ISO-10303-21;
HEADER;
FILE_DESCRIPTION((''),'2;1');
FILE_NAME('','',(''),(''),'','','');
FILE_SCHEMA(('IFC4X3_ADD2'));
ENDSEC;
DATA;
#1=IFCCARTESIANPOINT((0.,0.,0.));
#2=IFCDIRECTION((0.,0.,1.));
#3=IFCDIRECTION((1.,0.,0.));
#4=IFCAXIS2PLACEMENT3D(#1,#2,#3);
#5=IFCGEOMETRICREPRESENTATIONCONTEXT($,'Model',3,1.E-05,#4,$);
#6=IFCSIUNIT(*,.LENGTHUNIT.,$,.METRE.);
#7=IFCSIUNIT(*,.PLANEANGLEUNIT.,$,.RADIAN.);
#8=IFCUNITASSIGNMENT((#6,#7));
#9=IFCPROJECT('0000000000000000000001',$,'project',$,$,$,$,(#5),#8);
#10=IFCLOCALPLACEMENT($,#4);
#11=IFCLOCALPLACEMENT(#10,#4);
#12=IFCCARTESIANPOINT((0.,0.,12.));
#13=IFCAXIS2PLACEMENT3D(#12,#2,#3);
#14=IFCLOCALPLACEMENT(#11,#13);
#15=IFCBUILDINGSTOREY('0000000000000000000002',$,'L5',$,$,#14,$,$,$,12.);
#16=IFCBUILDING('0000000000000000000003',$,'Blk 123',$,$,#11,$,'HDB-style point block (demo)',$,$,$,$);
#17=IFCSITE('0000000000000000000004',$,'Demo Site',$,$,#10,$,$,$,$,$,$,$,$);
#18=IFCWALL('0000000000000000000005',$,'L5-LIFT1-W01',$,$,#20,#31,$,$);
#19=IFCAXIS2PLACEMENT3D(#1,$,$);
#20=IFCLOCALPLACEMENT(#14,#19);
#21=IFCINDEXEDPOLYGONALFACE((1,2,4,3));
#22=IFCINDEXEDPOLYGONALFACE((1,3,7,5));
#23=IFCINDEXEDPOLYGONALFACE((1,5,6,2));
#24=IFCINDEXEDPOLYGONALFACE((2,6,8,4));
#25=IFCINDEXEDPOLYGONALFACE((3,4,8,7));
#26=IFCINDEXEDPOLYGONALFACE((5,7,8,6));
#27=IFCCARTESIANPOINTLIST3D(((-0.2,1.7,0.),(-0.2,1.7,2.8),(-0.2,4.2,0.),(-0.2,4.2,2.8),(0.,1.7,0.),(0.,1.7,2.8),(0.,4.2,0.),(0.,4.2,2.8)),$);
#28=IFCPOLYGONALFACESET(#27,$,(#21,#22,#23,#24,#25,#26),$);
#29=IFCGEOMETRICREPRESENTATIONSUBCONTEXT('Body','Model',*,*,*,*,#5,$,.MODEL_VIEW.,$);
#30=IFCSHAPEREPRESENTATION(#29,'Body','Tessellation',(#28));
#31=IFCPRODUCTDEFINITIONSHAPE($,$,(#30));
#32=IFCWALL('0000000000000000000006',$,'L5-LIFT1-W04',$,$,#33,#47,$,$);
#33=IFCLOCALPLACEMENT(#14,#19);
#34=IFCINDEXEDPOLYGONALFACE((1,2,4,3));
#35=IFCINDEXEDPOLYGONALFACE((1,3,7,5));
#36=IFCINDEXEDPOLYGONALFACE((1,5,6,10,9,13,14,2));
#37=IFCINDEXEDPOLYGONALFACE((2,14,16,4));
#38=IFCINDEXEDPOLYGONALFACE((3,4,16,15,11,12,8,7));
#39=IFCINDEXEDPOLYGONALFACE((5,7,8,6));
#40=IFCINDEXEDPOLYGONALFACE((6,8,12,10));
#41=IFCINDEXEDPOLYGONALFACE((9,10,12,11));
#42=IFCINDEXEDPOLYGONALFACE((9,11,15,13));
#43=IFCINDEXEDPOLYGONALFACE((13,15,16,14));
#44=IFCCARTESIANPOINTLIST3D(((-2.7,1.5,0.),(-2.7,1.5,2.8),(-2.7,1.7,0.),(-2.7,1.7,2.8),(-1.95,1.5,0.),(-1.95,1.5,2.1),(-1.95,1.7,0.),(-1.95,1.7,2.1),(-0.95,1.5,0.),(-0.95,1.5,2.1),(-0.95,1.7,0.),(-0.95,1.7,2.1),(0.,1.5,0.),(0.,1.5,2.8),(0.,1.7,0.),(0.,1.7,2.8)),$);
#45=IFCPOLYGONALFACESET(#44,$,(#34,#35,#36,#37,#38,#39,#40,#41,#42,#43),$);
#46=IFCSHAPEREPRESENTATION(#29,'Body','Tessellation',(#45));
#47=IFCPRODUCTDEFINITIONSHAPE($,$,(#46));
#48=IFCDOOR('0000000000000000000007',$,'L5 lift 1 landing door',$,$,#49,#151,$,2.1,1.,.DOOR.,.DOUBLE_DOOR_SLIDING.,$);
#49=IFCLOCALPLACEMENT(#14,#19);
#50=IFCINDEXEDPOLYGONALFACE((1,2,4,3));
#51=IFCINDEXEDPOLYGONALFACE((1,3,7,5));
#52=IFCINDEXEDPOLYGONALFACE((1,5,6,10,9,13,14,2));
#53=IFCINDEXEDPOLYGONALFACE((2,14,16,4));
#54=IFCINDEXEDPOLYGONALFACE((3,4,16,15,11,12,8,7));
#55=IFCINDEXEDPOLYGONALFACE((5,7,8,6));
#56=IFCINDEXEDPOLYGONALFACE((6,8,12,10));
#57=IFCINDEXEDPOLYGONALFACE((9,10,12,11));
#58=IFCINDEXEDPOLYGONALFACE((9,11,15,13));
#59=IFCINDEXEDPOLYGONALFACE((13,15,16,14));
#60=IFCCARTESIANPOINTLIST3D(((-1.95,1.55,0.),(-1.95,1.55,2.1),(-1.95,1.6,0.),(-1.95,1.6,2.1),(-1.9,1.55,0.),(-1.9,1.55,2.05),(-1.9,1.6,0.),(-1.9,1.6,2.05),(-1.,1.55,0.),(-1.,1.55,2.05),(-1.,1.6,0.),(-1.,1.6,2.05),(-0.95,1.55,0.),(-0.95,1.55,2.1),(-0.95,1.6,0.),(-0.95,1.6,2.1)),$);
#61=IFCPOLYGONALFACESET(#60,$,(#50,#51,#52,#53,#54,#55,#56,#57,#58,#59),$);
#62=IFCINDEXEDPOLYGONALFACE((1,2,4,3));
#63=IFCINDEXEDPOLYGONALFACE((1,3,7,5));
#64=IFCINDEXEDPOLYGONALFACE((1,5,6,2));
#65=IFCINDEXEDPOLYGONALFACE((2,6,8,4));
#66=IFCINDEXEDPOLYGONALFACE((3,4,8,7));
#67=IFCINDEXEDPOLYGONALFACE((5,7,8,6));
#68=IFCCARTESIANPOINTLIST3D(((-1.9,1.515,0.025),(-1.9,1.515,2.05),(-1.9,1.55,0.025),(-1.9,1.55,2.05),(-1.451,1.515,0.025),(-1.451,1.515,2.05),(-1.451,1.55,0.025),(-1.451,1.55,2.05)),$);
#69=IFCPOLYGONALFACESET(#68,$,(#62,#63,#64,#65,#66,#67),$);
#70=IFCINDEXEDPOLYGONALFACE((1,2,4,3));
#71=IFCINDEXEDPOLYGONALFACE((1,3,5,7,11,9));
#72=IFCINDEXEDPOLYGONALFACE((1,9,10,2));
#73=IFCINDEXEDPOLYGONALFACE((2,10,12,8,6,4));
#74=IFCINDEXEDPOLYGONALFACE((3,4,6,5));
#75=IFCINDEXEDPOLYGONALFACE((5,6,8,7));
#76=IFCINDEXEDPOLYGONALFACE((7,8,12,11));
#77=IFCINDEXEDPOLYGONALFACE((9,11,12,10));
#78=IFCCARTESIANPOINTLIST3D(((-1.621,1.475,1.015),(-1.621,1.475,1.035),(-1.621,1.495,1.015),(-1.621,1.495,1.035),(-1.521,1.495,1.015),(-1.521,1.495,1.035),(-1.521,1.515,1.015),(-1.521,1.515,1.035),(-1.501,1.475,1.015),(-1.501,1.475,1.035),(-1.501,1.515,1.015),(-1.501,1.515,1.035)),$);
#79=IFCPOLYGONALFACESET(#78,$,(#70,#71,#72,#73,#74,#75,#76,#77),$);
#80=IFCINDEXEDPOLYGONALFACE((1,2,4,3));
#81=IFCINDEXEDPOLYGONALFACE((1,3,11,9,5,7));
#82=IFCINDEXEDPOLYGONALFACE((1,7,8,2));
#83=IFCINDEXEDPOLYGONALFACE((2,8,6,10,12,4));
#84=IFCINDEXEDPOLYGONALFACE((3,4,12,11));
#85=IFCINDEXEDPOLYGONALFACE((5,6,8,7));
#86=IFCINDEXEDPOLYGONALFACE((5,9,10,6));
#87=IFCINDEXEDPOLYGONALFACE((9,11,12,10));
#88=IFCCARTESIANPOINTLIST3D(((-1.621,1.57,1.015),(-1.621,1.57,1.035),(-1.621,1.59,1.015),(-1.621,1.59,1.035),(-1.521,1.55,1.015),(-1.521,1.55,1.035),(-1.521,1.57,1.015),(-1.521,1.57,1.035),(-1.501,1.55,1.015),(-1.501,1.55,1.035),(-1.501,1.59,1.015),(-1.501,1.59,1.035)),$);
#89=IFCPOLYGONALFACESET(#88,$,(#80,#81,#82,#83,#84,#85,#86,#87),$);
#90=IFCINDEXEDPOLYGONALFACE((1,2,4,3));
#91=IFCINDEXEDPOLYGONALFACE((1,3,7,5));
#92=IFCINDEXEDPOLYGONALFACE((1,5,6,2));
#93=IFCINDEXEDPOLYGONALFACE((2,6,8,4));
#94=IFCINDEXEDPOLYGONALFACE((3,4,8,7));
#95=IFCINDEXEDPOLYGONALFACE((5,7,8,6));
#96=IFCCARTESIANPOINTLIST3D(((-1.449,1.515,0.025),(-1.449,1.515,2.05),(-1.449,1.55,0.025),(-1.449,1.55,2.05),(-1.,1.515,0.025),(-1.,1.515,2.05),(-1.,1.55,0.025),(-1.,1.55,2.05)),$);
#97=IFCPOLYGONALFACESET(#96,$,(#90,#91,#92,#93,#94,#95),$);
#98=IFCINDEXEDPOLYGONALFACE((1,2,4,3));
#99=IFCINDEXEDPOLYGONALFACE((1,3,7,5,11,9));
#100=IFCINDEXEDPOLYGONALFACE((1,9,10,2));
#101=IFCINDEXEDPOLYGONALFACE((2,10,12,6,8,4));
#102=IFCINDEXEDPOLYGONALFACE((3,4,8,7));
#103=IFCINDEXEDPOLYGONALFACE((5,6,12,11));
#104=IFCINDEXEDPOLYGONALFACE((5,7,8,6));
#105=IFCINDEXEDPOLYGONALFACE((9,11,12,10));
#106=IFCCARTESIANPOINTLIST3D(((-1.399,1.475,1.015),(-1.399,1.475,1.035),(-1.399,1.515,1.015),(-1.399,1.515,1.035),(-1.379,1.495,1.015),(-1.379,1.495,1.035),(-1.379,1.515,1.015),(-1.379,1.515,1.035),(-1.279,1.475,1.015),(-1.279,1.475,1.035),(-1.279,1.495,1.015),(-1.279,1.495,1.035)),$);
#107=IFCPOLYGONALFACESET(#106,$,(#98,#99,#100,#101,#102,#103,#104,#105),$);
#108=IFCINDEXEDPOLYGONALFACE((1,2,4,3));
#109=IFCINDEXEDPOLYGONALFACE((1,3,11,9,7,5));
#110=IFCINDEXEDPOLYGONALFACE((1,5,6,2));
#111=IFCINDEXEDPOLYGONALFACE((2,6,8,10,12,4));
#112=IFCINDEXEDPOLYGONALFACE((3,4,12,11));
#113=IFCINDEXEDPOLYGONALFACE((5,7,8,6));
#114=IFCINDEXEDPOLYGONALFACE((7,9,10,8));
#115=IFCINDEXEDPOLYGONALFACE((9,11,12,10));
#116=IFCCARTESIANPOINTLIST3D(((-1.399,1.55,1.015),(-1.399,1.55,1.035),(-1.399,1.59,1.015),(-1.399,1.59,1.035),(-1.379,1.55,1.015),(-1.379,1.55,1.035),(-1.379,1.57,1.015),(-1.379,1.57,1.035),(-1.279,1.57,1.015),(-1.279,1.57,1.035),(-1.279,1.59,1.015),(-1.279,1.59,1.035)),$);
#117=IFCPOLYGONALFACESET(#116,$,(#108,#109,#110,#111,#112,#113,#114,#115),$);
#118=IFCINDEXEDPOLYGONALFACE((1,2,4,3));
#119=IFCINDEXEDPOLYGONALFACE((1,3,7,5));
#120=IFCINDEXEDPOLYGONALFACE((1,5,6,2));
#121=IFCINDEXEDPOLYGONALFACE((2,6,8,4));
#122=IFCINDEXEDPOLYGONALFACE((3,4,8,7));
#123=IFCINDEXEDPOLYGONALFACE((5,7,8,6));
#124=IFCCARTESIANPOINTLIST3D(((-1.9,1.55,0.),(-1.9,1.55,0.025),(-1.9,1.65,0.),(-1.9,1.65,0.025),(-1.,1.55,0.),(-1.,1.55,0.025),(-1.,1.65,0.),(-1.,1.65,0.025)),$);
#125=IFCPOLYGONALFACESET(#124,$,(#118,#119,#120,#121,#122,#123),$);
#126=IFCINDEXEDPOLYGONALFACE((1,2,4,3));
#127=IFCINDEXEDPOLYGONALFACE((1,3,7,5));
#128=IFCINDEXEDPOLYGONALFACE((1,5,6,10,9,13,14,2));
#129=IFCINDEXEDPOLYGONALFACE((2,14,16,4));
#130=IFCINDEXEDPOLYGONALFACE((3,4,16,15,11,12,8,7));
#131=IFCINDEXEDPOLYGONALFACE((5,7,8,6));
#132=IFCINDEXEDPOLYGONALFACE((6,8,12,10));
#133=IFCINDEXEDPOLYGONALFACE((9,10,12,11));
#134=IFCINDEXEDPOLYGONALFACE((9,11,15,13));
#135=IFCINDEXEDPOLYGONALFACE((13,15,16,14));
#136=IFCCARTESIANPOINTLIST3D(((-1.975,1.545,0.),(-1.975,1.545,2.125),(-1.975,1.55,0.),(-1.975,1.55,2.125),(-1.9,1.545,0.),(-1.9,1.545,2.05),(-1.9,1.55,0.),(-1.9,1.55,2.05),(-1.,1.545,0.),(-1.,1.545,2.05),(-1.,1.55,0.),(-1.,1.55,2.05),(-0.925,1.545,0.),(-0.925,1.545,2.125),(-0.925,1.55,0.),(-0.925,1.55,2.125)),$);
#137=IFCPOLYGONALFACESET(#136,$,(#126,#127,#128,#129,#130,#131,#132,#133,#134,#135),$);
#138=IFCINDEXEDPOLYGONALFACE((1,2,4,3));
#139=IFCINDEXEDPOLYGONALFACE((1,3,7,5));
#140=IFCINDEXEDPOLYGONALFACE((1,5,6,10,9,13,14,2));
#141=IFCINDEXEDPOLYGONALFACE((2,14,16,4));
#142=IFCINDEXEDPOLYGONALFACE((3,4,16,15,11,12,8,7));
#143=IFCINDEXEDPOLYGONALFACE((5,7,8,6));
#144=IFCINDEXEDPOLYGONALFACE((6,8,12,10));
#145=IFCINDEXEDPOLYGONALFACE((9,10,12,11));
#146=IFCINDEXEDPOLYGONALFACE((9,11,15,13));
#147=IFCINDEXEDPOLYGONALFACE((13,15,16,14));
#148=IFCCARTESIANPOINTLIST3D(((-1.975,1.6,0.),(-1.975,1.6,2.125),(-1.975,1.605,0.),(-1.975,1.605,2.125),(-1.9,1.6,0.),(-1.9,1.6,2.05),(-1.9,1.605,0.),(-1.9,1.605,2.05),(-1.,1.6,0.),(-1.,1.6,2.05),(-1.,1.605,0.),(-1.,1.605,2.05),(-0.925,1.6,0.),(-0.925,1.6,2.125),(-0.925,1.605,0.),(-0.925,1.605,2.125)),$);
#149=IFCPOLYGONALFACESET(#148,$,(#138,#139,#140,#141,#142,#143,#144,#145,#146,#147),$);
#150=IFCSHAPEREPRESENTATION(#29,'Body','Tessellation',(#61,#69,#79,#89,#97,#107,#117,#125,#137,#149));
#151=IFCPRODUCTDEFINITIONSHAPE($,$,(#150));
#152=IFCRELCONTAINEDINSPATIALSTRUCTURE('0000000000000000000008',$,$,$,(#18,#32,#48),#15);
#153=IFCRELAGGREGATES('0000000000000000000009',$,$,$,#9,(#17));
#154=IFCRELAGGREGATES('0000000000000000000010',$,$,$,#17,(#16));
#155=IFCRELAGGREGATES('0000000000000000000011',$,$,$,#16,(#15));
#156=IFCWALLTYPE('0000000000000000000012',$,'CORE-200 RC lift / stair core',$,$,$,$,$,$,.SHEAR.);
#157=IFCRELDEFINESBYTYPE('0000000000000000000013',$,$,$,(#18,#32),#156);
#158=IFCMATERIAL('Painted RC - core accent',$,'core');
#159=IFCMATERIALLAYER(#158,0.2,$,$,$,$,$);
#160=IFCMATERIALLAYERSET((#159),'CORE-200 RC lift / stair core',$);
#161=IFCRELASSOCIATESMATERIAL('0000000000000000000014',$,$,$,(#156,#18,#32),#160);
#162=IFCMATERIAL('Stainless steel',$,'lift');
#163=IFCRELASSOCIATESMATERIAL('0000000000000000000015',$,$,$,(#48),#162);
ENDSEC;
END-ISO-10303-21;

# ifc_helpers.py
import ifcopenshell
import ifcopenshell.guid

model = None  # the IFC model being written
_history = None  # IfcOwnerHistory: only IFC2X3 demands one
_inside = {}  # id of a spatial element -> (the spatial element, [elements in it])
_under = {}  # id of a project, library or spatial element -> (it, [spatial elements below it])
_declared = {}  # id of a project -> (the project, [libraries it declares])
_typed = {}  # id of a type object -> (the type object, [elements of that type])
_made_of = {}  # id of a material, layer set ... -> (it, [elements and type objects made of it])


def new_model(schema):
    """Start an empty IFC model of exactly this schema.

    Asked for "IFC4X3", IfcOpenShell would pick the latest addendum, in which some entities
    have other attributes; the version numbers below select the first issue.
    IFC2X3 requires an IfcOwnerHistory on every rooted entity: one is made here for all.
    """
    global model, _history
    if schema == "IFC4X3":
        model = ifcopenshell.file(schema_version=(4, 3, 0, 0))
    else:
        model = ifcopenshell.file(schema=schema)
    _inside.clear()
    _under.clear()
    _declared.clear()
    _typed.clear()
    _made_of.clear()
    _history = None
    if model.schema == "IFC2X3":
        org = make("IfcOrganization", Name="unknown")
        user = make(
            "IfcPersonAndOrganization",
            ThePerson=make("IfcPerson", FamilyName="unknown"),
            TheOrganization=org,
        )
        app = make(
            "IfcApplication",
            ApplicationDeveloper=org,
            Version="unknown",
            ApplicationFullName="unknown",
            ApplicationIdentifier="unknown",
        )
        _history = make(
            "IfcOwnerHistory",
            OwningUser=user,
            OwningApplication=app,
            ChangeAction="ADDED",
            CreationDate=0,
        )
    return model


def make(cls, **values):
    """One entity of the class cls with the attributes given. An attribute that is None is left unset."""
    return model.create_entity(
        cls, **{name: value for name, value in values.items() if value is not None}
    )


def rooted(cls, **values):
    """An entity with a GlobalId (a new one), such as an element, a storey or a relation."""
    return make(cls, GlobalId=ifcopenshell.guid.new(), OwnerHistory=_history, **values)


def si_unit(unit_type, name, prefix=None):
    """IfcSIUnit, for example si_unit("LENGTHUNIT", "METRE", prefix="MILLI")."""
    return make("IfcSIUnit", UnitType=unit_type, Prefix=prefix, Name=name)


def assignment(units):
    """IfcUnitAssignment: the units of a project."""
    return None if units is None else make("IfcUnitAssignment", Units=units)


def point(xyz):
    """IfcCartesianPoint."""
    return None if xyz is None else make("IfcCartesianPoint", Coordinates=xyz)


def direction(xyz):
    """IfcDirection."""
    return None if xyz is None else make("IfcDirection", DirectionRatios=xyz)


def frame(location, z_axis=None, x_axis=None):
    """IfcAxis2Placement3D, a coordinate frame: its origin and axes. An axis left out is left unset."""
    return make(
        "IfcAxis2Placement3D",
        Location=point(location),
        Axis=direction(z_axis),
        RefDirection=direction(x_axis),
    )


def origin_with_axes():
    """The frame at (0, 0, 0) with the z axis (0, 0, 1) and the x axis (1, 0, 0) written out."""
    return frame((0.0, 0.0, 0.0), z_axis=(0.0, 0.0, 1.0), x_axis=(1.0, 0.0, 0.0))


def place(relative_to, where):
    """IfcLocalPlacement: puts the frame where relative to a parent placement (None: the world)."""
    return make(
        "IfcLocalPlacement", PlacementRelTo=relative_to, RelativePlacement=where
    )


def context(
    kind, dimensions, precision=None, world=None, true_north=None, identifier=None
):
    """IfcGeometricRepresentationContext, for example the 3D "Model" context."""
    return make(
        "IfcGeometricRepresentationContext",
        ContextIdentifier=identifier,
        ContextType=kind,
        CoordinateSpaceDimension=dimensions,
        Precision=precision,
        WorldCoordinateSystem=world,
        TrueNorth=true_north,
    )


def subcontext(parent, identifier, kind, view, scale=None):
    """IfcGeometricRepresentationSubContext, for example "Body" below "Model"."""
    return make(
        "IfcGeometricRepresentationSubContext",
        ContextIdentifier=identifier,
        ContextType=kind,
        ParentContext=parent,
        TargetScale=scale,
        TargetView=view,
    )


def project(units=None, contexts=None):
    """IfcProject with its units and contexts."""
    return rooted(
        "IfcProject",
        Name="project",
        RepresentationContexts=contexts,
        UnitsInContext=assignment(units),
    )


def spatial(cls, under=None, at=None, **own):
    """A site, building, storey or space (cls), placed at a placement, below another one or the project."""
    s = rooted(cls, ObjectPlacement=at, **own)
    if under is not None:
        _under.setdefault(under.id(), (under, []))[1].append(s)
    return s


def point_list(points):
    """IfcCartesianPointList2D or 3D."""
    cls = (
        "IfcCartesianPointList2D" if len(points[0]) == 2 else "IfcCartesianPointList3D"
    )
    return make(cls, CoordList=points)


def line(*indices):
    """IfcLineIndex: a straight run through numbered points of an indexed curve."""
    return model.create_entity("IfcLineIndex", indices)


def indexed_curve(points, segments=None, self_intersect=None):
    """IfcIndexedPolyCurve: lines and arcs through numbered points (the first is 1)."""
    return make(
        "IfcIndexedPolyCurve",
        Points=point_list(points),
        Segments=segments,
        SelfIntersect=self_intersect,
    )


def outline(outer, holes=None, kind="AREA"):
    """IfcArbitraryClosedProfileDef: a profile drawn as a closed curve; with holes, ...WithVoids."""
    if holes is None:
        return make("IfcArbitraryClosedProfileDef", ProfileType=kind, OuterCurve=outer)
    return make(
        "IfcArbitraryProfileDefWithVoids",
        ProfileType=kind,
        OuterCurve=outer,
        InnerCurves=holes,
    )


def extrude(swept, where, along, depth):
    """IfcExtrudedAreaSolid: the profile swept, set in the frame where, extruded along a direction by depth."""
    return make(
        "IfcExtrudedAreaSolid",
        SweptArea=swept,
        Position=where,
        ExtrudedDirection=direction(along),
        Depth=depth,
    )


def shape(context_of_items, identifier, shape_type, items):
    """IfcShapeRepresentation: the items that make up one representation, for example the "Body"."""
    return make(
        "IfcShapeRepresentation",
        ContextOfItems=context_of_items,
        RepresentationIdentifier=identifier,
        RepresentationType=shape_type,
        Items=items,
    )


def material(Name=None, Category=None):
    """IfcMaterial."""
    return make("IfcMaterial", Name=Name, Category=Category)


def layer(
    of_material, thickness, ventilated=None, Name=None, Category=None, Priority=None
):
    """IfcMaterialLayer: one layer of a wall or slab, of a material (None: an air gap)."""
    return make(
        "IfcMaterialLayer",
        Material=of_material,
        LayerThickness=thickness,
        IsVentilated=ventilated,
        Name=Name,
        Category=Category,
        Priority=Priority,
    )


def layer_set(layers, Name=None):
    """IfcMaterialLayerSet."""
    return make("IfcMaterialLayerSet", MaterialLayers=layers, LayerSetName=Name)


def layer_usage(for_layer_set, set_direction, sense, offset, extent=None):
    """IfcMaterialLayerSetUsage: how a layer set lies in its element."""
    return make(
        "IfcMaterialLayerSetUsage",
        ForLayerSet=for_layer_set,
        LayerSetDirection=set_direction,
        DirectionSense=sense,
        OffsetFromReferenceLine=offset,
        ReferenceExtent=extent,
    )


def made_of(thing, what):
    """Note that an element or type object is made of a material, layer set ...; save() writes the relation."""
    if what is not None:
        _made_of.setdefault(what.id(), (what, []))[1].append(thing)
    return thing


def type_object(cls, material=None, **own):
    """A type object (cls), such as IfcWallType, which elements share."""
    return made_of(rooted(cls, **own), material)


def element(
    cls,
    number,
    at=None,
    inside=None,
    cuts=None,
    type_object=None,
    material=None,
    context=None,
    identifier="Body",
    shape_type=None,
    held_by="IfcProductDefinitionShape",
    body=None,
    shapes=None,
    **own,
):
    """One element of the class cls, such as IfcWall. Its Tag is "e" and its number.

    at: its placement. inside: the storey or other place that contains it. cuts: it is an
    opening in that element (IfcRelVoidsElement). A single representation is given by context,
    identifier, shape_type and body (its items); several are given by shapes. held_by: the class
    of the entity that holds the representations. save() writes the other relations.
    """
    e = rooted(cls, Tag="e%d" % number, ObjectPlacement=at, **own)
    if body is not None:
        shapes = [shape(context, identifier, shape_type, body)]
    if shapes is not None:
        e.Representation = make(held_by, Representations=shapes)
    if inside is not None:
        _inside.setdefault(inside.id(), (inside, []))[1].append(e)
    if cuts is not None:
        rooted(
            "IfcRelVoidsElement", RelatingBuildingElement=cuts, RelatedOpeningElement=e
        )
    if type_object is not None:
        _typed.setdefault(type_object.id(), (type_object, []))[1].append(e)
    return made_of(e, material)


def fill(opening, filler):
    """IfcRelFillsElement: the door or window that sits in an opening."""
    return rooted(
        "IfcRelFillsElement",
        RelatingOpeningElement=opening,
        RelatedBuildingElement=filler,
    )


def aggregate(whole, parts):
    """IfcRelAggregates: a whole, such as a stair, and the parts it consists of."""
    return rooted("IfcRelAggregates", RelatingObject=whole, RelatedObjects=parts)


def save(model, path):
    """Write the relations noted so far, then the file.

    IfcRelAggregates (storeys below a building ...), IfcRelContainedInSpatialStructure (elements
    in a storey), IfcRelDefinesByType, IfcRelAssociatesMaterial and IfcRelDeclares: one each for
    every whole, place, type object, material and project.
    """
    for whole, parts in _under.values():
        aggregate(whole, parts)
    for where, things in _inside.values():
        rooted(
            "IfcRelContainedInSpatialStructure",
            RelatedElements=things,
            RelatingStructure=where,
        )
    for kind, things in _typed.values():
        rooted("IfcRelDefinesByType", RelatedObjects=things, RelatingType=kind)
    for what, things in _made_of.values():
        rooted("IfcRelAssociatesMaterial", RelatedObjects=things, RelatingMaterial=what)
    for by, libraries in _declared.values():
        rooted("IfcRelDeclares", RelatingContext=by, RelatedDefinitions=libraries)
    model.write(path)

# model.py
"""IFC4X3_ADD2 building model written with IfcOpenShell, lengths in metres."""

from ifc_helpers import new_model, si_unit, frame, origin_with_axes, place, context, subcontext, project, spatial, line, indexed_curve, outline, extrude, material, layer, layer_set, layer_usage, type_object, element, fill, save


model = new_model("IFC4X3_ADD2")

# Units and contexts
model_context = context("Model", 3, precision=1e-05, world=origin_with_axes())
body_context = subcontext(model_context, "Body", "Model", "MODEL_VIEW")
ifc_project = project(units=[si_unit("LENGTHUNIT", "METRE"), si_unit("PLANEANGLEUNIT", "RADIAN")], contexts=[model_context])

# Site, building, storey
site_placement = place(None, origin_with_axes())
site = spatial("IfcSite", under=ifc_project, at=site_placement, Name="Demo Site")
building_placement = place(site_placement, origin_with_axes())
building = spatial("IfcBuilding", under=site, at=building_placement, Name="Blk 123", LongName="HDB-style point block (demo)")
storey_placement = place(building_placement, frame((0.0, 0.0, 12.0), z_axis=(0.0, 0.0, 1.0), x_axis=(1.0, 0.0, 0.0)))
storey = spatial("IfcBuildingStorey", under=building, at=storey_placement, Name="L5", Elevation=12.0)

# Wall
ifc_material_1 = material(Name="Painted RC - core accent", Category="core")
ifc_layer_1 = layer(ifc_material_1, 0.2)
ifc_layer_set_1 = layer_set([ifc_layer_1], Name="CORE-200 RC lift / stair core")
ifc_layer_usage_1 = layer_usage(ifc_layer_set_1, "AXIS2", "POSITIVE", 0.0)
wall_type_1 = type_object("IfcWallType", Name="CORE-200 RC lift / stair core", PredefinedType="SHEAR", material=ifc_layer_set_1)
wall_1_placement = place(storey_placement, frame((0.0, 1.7, 0.0), z_axis=(0.0, 0.0, 1.0), x_axis=(0.0, 1.0, 0.0)))
element("IfcWall", 1, at=wall_1_placement, inside=storey, type_object=wall_type_1, material=ifc_layer_usage_1, Name="L5-LIFT1-W01", context=body_context, shape_type="SweptSolid", body=[
    extrude(outline(indexed_curve([(0.0, 0.0), (0.0, 0.2), (2.5, 0.2), (2.5, 0.0), (0.0, 0.0)], self_intersect=False)), origin_with_axes(), (0.0, 0.0, 1.0), 2.8),
])

# Wall, opening, door
wall_2_placement = place(storey_placement, frame((-2.7, 1.5, 0.0), z_axis=(0.0, 0.0, 1.0), x_axis=(1.0, 0.0, 0.0)))
wall_2 = element("IfcWall", 2, at=wall_2_placement, inside=storey, type_object=wall_type_1, material=ifc_layer_usage_1, Name="L5-LIFT1-W04", context=body_context, shape_type="SweptSolid", body=[
    extrude(outline(indexed_curve([(0.0, 0.0), (0.0, 0.2), (2.7, 0.2), (2.7, 0.0), (0.0, 0.0)], self_intersect=False)), origin_with_axes(), (0.0, 0.0, 1.0), 2.8),
])
opening_1_placement = place(wall_2_placement, frame((0.75, -0.1, 0.0), z_axis=(0.0, 0.0, 1.0), x_axis=(1.0, 0.0, 0.0)))
opening_1 = element("IfcOpeningElement", 3, at=opening_1_placement, cuts=wall_2, context=body_context, shape_type="SweptSolid", body=[
    extrude(outline(indexed_curve([(0.0, 0.0), (0.0, 0.4), (1.0, 0.4), (1.0, 0.0), (0.0, 0.0)], self_intersect=False)), origin_with_axes(), (0.0, 0.0, 1.0), 2.1),
])
ifc_material_2 = material(Name="Stainless steel", Category="lift")
door_1_placement = place(opening_1_placement, frame((0.0, 0.15, 0.0), z_axis=(0.0, 0.0, 1.0), x_axis=(1.0, 0.0, 0.0)))
door_1 = element("IfcDoor", 4, at=door_1_placement, inside=storey, material=ifc_material_2, Name="L5 lift 1 landing door", OperationType="DOUBLE_DOOR_SLIDING", OverallHeight=2.1, OverallWidth=1.0, PredefinedType="DOOR", context=body_context, shape_type="SweptSolid", body=[
    extrude(outline(indexed_curve([(0.0, 0.0), (0.0, 2.1), (1.0, 2.1), (1.0, 0.0), (0.95, 0.0), (0.95, 2.05), (0.05, 2.05), (0.05, 0.0)], segments=[line(1, 2, 3, 4, 5, 6, 7, 8, 1)])), frame((0.0, 0.0, 0.0), z_axis=(0.0, -1.0, 0.0), x_axis=(1.0, 0.0, 0.0)), (0.0, 0.0, -1.0), 0.05),
    extrude(outline(indexed_curve([(0.0, 0.0), (0.449, 0.0), (0.449, 0.035), (0.0, 0.035)], segments=[line(1, 2, 3, 4, 1)])), frame((0.05, -0.035, 0.025), z_axis=(0.0, 0.0, 1.0), x_axis=(1.0, 0.0, 0.0)), (0.0, 0.0, 1.0), 2.025),
    extrude(outline(indexed_curve([(0.0, 0.0), (0.0, -0.04), (-0.12, -0.04), (-0.12, -0.02), (-0.02, -0.02), (-0.02, 0.0)], segments=[line(1, 2, 3, 4, 5, 6, 1)])), frame((0.449, -0.035, 1.015), z_axis=(0.0, 0.0, 1.0), x_axis=(1.0, 0.0, 0.0)), (0.0, 0.0, 1.0), 0.02),
    extrude(outline(indexed_curve([(0.0, 0.0), (0.0, 0.04), (-0.12, 0.04), (-0.12, 0.02), (-0.02, 0.02), (-0.02, 0.0)], segments=[line(1, 2, 3, 4, 5, 6, 1)])), frame((0.449, 0.0, 1.015), z_axis=(0.0, 0.0, 1.0), x_axis=(1.0, 0.0, 0.0)), (0.0, 0.0, 1.0), 0.02),
    extrude(outline(indexed_curve([(0.0, 0.0), (-0.449, 0.0), (-0.449, 0.035), (0.0, 0.035)], segments=[line(1, 2, 3, 4, 1)])), frame((0.95, -0.035, 0.025), z_axis=(0.0, 0.0, 1.0), x_axis=(1.0, 0.0, 0.0)), (0.0, 0.0, 1.0), 2.025),
    extrude(outline(indexed_curve([(0.0, 0.0), (0.0, -0.04), (0.12, -0.04), (0.12, -0.02), (0.02, -0.02), (0.02, 0.0)], segments=[line(1, 2, 3, 4, 5, 6, 1)])), frame((0.551, -0.035, 1.015), z_axis=(0.0, 0.0, 1.0), x_axis=(1.0, 0.0, 0.0)), (0.0, 0.0, 1.0), 0.02),
    extrude(outline(indexed_curve([(0.0, 0.0), (0.0, 0.04), (0.12, 0.04), (0.12, 0.02), (0.02, 0.02), (0.02, 0.0)], segments=[line(1, 2, 3, 4, 5, 6, 1)])), frame((0.551, 0.0, 1.015), z_axis=(0.0, 0.0, 1.0), x_axis=(1.0, 0.0, 0.0)), (0.0, 0.0, 1.0), 0.02),
    extrude(outline(indexed_curve([(0.0, 0.0), (0.9, 0.0), (0.9, 0.1), (0.0, 0.1)], segments=[line(1, 2, 3, 4, 1)])), frame((0.05, 0.0, 0.0), z_axis=(0.0, 0.0, 1.0), x_axis=(1.0, 0.0, 0.0)), (0.0, 0.0, 1.0), 0.025),
    extrude(outline(indexed_curve([(0.0, 0.0), (0.0, 2.125), (1.05, 2.125), (1.05, 0.0), (0.975, 0.0), (0.975, 2.05), (0.075, 2.05), (0.075, 0.0)], segments=[line(1, 2, 3, 4, 5, 6, 7, 8, 1)])), frame((-0.025, -0.005, 0.0), z_axis=(0.0, -1.0, 0.0), x_axis=(1.0, 0.0, 0.0)), (0.0, 0.0, -1.0), 0.005),
    extrude(outline(indexed_curve([(0.0, 0.0), (0.0, 2.125), (1.05, 2.125), (1.05, 0.0), (0.975, 0.0), (0.975, 2.05), (0.075, 2.05), (0.075, 0.0)], segments=[line(1, 2, 3, 4, 5, 6, 7, 8, 1)])), frame((-0.025, 0.05, 0.0), z_axis=(0.0, -1.0, 0.0), x_axis=(1.0, 0.0, 0.0)), (0.0, 0.0, -1.0), 0.005),
])
fill(opening_1, door_1)

save(model, "model.ifc")
